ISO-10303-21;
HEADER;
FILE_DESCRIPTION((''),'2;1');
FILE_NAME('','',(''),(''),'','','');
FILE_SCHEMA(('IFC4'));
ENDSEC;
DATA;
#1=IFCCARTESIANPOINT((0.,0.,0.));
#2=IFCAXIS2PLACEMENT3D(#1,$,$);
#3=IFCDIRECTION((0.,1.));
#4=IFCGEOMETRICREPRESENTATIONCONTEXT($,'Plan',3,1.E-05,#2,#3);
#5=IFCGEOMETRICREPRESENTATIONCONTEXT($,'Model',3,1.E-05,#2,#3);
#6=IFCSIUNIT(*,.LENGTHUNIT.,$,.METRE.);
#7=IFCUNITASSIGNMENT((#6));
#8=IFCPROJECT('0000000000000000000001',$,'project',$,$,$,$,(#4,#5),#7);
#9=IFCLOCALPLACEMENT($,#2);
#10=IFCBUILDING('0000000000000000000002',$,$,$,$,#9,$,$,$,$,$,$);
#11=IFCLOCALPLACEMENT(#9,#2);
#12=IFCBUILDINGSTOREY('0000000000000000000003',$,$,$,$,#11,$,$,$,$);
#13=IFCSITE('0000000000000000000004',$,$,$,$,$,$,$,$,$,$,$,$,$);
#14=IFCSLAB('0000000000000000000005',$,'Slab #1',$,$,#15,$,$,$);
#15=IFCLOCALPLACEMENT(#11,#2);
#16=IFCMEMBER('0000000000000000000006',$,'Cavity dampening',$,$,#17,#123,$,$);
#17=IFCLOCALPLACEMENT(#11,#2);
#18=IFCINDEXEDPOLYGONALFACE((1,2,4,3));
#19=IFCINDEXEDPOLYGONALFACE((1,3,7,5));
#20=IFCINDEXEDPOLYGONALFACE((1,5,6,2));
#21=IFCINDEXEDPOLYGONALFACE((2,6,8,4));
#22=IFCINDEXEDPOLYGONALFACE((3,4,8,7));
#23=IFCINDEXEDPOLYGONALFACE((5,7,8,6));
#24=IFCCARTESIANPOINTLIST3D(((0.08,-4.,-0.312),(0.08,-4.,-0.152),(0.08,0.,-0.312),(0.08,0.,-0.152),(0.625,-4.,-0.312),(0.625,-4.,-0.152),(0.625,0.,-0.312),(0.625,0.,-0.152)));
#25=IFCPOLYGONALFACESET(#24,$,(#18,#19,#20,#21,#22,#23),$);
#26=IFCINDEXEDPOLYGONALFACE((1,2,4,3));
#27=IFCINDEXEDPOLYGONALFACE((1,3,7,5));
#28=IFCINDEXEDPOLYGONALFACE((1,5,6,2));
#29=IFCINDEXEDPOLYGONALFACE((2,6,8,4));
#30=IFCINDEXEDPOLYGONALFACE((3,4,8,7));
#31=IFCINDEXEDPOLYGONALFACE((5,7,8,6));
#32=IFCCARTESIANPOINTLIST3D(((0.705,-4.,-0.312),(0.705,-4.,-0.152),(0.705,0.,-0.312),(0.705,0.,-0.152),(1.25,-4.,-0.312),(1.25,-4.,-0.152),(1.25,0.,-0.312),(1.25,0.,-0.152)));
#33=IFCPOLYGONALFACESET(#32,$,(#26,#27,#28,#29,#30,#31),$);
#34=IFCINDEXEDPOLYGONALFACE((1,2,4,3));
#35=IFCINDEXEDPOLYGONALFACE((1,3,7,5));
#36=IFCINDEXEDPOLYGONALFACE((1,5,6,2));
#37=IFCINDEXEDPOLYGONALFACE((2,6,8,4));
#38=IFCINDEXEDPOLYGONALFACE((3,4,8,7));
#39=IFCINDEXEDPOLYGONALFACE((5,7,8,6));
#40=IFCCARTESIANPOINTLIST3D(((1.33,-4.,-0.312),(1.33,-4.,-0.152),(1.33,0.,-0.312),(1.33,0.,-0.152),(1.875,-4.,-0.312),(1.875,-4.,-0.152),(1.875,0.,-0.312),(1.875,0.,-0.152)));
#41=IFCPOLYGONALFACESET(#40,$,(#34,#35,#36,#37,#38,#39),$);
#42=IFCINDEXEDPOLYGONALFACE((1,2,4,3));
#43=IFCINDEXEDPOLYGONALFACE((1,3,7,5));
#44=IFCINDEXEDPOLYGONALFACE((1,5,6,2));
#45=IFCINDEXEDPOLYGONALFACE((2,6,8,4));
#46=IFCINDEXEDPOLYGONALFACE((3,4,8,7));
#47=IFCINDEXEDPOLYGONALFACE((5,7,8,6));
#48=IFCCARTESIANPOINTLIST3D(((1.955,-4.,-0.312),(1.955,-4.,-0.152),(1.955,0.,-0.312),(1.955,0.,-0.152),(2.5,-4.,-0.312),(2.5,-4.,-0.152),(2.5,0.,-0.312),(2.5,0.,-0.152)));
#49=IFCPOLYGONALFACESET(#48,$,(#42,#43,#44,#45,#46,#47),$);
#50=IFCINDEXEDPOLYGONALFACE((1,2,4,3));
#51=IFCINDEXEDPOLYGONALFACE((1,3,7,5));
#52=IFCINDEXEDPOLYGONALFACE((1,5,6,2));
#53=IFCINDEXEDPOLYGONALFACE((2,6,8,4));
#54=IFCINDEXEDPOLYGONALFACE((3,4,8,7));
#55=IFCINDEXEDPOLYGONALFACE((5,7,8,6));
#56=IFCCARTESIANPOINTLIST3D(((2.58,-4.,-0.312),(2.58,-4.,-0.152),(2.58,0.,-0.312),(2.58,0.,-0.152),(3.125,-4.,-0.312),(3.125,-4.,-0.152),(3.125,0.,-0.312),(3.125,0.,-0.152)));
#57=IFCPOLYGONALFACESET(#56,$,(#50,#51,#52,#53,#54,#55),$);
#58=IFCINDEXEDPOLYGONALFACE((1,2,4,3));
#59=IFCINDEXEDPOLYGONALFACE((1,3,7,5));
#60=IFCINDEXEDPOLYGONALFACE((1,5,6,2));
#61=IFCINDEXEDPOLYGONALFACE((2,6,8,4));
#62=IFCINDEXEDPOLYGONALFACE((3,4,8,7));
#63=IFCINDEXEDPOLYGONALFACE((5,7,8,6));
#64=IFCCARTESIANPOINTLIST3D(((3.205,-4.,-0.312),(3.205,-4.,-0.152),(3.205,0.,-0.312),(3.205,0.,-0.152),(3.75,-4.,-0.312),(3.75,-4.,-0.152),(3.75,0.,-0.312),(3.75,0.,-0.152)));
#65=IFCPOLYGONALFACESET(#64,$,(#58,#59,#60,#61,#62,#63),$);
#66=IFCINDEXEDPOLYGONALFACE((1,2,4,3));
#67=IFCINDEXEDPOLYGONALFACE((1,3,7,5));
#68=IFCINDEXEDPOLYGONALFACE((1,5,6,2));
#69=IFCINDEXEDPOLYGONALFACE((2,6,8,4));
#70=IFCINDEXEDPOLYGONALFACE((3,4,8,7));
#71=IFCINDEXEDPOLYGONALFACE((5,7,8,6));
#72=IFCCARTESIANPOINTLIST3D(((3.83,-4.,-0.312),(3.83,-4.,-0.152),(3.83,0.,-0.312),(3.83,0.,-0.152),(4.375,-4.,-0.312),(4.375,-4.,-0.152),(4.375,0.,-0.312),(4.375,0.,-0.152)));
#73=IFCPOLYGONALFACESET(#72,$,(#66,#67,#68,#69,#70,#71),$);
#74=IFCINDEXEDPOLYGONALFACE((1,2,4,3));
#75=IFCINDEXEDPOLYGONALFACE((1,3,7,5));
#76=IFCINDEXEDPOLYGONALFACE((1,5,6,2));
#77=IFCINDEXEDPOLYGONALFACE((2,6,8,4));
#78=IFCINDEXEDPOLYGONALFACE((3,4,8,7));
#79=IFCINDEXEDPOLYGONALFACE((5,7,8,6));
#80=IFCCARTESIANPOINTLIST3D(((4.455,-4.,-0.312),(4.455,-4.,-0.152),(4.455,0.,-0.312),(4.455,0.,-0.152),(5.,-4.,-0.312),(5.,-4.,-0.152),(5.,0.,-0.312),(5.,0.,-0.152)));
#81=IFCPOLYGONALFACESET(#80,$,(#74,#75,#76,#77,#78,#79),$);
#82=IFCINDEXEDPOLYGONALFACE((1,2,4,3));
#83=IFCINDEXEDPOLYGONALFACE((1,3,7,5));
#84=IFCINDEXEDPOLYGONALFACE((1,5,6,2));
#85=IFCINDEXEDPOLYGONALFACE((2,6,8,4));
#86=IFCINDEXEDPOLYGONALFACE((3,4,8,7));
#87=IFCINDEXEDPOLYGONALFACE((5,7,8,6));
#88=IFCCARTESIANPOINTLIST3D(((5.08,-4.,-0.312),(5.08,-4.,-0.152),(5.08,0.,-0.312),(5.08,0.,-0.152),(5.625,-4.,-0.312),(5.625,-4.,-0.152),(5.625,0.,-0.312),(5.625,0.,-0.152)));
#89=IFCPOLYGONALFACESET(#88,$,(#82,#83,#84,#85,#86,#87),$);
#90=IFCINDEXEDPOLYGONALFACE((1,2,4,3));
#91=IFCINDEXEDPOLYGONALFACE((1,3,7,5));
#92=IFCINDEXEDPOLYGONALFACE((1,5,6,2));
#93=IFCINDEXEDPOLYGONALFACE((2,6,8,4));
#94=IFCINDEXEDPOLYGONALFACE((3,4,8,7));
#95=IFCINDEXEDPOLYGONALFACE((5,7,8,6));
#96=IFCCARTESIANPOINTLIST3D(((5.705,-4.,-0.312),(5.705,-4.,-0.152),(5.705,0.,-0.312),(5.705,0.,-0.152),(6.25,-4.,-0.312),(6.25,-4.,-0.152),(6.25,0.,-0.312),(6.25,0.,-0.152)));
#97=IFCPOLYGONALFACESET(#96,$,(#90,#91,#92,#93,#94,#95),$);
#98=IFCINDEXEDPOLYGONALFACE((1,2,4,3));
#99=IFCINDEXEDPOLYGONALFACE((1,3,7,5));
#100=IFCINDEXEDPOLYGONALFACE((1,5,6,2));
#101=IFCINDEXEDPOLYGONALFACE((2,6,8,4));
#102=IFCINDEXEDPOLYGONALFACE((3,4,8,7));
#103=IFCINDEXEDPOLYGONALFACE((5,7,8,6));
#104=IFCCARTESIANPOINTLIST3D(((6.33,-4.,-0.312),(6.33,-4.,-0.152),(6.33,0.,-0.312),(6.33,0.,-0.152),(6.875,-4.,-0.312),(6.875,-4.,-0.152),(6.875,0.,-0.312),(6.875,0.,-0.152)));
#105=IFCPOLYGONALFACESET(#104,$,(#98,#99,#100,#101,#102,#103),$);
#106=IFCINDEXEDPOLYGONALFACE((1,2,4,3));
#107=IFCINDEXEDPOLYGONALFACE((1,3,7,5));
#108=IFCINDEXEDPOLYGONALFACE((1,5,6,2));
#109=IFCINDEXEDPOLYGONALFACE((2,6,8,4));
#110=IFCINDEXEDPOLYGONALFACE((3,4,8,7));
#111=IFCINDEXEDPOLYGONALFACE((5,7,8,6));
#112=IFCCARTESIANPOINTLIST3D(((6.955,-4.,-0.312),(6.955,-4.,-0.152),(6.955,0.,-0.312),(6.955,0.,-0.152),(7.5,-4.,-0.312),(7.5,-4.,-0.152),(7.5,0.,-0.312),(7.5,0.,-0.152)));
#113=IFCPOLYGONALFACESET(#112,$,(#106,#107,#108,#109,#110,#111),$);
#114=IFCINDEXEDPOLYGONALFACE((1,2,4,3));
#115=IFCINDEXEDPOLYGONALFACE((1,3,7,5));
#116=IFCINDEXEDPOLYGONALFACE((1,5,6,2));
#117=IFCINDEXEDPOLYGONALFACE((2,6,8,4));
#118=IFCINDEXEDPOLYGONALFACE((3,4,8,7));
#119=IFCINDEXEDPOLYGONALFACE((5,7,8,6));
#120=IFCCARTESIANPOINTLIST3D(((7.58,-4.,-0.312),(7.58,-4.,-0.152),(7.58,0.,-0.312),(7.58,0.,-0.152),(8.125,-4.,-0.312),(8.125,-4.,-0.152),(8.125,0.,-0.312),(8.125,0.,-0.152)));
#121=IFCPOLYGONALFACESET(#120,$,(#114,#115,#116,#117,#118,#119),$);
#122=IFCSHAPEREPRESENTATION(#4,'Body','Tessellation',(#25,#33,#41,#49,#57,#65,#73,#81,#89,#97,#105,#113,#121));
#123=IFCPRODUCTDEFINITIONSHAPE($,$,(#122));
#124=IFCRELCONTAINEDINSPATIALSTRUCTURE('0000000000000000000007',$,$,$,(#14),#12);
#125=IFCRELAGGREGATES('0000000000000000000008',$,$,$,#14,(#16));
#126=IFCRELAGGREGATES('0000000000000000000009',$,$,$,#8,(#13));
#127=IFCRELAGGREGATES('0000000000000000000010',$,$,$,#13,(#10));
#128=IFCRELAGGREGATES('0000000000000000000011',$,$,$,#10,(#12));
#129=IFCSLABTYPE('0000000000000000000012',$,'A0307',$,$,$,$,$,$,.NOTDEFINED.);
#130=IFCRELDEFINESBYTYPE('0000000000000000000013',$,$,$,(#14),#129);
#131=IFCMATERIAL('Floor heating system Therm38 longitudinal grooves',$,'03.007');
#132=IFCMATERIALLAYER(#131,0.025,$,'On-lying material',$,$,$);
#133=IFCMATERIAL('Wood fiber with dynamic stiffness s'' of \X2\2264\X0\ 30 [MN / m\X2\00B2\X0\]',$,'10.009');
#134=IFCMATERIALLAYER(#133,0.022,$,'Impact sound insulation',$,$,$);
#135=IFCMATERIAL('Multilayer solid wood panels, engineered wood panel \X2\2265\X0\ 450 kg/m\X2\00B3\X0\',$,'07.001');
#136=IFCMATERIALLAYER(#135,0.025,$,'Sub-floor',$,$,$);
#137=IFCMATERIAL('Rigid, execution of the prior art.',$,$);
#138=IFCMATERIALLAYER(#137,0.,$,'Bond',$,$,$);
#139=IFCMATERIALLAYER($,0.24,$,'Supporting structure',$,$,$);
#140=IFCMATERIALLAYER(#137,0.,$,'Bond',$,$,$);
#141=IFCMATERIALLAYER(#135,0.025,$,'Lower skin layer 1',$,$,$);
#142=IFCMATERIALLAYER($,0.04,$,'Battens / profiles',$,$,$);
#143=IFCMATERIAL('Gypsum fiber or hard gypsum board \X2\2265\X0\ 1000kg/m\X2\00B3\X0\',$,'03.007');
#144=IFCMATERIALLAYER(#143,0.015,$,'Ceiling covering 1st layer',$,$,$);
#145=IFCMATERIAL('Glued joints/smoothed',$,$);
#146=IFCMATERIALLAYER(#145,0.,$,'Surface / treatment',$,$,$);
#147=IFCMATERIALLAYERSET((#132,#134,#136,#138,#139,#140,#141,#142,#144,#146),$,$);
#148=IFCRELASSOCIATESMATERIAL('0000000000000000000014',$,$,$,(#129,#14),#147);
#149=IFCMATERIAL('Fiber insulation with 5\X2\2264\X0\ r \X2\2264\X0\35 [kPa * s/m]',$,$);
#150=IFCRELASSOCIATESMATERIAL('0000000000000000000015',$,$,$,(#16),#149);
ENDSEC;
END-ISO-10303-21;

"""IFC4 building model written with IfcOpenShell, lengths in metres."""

from ifc_helpers import new_model, si_unit, direction, frame, frame_2d, origin, place, context, project, spatial, rectangle, extrude, material, layer, layer_set, type_object, element, aggregate, save


model = new_model("IFC4")

# Units and contexts
plan_context = context("Plan", 3, precision=1e-05, world=origin(), true_north=direction((0.0, 1.0)))
model_context = context("Model", 3, precision=1e-05, world=origin(), true_north=direction((0.0, 1.0)))
ifc_project = project(units=[si_unit("LENGTHUNIT", "METRE")], contexts=[plan_context, model_context])

# Site, building, storey
site = spatial("IfcSite", under=ifc_project)
building_placement = place(None, origin())
building = spatial("IfcBuilding", under=site, at=building_placement)
storey_placement = place(building_placement, origin())
storey = spatial("IfcBuildingStorey", under=building, at=storey_placement)

# Slab, member
ifc_material_1 = material(Name="Floor heating system Therm38 longitudinal grooves", Category="03.007")
ifc_layer_1 = layer(ifc_material_1, 0.025, Name="On-lying material")
ifc_material_2 = material(Name="Wood fiber with dynamic stiffness s' of ≤ 30 [MN / m²]", Category="10.009")
ifc_layer_2 = layer(ifc_material_2, 0.022, Name="Impact sound insulation")
ifc_material_3 = material(Name="Multilayer solid wood panels, engineered wood panel ≥ 450 kg/m³", Category="07.001")
ifc_layer_3 = layer(ifc_material_3, 0.025, Name="Sub-floor")
ifc_material_4 = material(Name="Rigid, execution of the prior art.")
ifc_layer_4 = layer(ifc_material_4, 0.0, Name="Bond")
ifc_layer_5 = layer(None, 0.24, Name="Supporting structure")
ifc_layer_6 = layer(ifc_material_4, 0.0, Name="Bond")
ifc_layer_7 = layer(ifc_material_3, 0.025, Name="Lower skin layer 1")
ifc_layer_8 = layer(None, 0.04, Name="Battens / profiles")
ifc_material_5 = material(Name="Gypsum fiber or hard gypsum board ≥ 1000kg/m³", Category="03.007")
ifc_layer_9 = layer(ifc_material_5, 0.015, Name="Ceiling covering 1st layer")
ifc_material_6 = material(Name="Glued joints/smoothed")
ifc_layer_10 = layer(ifc_material_6, 0.0, Name="Surface / treatment")
ifc_layer_set = layer_set([ifc_layer_1, ifc_layer_2, ifc_layer_3, ifc_layer_4, ifc_layer_5, ifc_layer_6, ifc_layer_7, ifc_layer_8, ifc_layer_9, ifc_layer_10])
slab_type = type_object("IfcSlabType", Name="A0307", PredefinedType="NOTDEFINED", material=ifc_layer_set)
slab_placement = place(None, frame((0.0, 0.0, 0.0), z_axis=(0.0, 0.0, -1.0), x_axis=(1.0, 0.0, 0.0)))
slab = element("IfcSlab", 1, at=slab_placement, inside=storey, type_object=slab_type, material=ifc_layer_set, Name="Slab #1")
ifc_material_7 = material(Name="Fiber insulation with 5≤ r ≤35 [kPa * s/m]")
member_1_placement = place(slab_placement, origin())
member_1 = element("IfcMember", 2, at=member_1_placement, material=ifc_material_7, Name="Cavity dampening", context=plan_context, shape_type="SweptSolid", body=[
    extrude(rectangle(XDim=0.545, YDim=0.16, at=frame_2d((0.2725, 0.08), x_axis=(1.0, 0.0))), frame((0.08, 4.0, 0.152), z_axis=(0.0, -1.0, 0.0), x_axis=(1.0, 0.0, 0.0)), (0.0, 0.0, 1.0), 4.0),
    extrude(rectangle(XDim=0.545, YDim=0.16, at=frame_2d((0.2725, 0.08), x_axis=(1.0, 0.0))), frame((0.705, 4.0, 0.152), z_axis=(0.0, -1.0, 0.0), x_axis=(1.0, 0.0, 0.0)), (0.0, 0.0, 1.0), 4.0),
    extrude(rectangle(XDim=0.545, YDim=0.16, at=frame_2d((0.2725, 0.08), x_axis=(1.0, 0.0))), frame((1.33, 4.0, 0.152), z_axis=(0.0, -1.0, 0.0), x_axis=(1.0, 0.0, 0.0)), (0.0, 0.0, 1.0), 4.0),
    extrude(rectangle(XDim=0.545, YDim=0.16, at=frame_2d((0.2725, 0.08), x_axis=(1.0, 0.0))), frame((1.955, 4.0, 0.152), z_axis=(0.0, -1.0, 0.0), x_axis=(1.0, 0.0, 0.0)), (0.0, 0.0, 1.0), 4.0),
    extrude(rectangle(XDim=0.545, YDim=0.16, at=frame_2d((0.2725, 0.08), x_axis=(1.0, 0.0))), frame((2.58, 4.0, 0.152), z_axis=(0.0, -1.0, 0.0), x_axis=(1.0, 0.0, 0.0)), (0.0, 0.0, 1.0), 4.0),
    extrude(rectangle(XDim=0.545, YDim=0.16, at=frame_2d((0.2725, 0.08), x_axis=(1.0, 0.0))), frame((3.205, 4.0, 0.152), z_axis=(0.0, -1.0, 0.0), x_axis=(1.0, 0.0, 0.0)), (0.0, 0.0, 1.0), 4.0),
    extrude(rectangle(XDim=0.545, YDim=0.16, at=frame_2d((0.2725, 0.08), x_axis=(1.0, 0.0))), frame((3.83, 4.0, 0.152), z_axis=(0.0, -1.0, 0.0), x_axis=(1.0, 0.0, 0.0)), (0.0, 0.0, 1.0), 4.0),
    extrude(rectangle(XDim=0.545, YDim=0.16, at=frame_2d((0.2725, 0.08), x_axis=(1.0, 0.0))), frame((4.455, 4.0, 0.152), z_axis=(0.0, -1.0, 0.0), x_axis=(1.0, 0.0, 0.0)), (0.0, 0.0, 1.0), 4.0),
    extrude(rectangle(XDim=0.545, YDim=0.16, at=frame_2d((0.2725, 0.08), x_axis=(1.0, 0.0))), frame((5.08, 4.0, 0.152), z_axis=(0.0, -1.0, 0.0), x_axis=(1.0, 0.0, 0.0)), (0.0, 0.0, 1.0), 4.0),
    extrude(rectangle(XDim=0.545, YDim=0.16, at=frame_2d((0.2725, 0.08), x_axis=(1.0, 0.0))), frame((5.705, 4.0, 0.152), z_axis=(0.0, -1.0, 0.0), x_axis=(1.0, 0.0, 0.0)), (0.0, 0.0, 1.0), 4.0),
    extrude(rectangle(XDim=0.545, YDim=0.16, at=frame_2d((0.2725, 0.08), x_axis=(1.0, 0.0))), frame((6.33, 4.0, 0.152), z_axis=(0.0, -1.0, 0.0), x_axis=(1.0, 0.0, 0.0)), (0.0, 0.0, 1.0), 4.0),
    extrude(rectangle(XDim=0.545, YDim=0.16, at=frame_2d((0.2725, 0.08), x_axis=(1.0, 0.0))), frame((6.955, 4.0, 0.152), z_axis=(0.0, -1.0, 0.0), x_axis=(1.0, 0.0, 0.0)), (0.0, 0.0, 1.0), 4.0),
    extrude(rectangle(XDim=0.545, YDim=0.16, at=frame_2d((0.2725, 0.08), x_axis=(1.0, 0.0))), frame((7.58, 4.0, 0.152), z_axis=(0.0, -1.0, 0.0), x_axis=(1.0, 0.0, 0.0)), (0.0, 0.0, 1.0), 4.0),
])
aggregate(slab, [member_1])

save(model, "model.ifc")
